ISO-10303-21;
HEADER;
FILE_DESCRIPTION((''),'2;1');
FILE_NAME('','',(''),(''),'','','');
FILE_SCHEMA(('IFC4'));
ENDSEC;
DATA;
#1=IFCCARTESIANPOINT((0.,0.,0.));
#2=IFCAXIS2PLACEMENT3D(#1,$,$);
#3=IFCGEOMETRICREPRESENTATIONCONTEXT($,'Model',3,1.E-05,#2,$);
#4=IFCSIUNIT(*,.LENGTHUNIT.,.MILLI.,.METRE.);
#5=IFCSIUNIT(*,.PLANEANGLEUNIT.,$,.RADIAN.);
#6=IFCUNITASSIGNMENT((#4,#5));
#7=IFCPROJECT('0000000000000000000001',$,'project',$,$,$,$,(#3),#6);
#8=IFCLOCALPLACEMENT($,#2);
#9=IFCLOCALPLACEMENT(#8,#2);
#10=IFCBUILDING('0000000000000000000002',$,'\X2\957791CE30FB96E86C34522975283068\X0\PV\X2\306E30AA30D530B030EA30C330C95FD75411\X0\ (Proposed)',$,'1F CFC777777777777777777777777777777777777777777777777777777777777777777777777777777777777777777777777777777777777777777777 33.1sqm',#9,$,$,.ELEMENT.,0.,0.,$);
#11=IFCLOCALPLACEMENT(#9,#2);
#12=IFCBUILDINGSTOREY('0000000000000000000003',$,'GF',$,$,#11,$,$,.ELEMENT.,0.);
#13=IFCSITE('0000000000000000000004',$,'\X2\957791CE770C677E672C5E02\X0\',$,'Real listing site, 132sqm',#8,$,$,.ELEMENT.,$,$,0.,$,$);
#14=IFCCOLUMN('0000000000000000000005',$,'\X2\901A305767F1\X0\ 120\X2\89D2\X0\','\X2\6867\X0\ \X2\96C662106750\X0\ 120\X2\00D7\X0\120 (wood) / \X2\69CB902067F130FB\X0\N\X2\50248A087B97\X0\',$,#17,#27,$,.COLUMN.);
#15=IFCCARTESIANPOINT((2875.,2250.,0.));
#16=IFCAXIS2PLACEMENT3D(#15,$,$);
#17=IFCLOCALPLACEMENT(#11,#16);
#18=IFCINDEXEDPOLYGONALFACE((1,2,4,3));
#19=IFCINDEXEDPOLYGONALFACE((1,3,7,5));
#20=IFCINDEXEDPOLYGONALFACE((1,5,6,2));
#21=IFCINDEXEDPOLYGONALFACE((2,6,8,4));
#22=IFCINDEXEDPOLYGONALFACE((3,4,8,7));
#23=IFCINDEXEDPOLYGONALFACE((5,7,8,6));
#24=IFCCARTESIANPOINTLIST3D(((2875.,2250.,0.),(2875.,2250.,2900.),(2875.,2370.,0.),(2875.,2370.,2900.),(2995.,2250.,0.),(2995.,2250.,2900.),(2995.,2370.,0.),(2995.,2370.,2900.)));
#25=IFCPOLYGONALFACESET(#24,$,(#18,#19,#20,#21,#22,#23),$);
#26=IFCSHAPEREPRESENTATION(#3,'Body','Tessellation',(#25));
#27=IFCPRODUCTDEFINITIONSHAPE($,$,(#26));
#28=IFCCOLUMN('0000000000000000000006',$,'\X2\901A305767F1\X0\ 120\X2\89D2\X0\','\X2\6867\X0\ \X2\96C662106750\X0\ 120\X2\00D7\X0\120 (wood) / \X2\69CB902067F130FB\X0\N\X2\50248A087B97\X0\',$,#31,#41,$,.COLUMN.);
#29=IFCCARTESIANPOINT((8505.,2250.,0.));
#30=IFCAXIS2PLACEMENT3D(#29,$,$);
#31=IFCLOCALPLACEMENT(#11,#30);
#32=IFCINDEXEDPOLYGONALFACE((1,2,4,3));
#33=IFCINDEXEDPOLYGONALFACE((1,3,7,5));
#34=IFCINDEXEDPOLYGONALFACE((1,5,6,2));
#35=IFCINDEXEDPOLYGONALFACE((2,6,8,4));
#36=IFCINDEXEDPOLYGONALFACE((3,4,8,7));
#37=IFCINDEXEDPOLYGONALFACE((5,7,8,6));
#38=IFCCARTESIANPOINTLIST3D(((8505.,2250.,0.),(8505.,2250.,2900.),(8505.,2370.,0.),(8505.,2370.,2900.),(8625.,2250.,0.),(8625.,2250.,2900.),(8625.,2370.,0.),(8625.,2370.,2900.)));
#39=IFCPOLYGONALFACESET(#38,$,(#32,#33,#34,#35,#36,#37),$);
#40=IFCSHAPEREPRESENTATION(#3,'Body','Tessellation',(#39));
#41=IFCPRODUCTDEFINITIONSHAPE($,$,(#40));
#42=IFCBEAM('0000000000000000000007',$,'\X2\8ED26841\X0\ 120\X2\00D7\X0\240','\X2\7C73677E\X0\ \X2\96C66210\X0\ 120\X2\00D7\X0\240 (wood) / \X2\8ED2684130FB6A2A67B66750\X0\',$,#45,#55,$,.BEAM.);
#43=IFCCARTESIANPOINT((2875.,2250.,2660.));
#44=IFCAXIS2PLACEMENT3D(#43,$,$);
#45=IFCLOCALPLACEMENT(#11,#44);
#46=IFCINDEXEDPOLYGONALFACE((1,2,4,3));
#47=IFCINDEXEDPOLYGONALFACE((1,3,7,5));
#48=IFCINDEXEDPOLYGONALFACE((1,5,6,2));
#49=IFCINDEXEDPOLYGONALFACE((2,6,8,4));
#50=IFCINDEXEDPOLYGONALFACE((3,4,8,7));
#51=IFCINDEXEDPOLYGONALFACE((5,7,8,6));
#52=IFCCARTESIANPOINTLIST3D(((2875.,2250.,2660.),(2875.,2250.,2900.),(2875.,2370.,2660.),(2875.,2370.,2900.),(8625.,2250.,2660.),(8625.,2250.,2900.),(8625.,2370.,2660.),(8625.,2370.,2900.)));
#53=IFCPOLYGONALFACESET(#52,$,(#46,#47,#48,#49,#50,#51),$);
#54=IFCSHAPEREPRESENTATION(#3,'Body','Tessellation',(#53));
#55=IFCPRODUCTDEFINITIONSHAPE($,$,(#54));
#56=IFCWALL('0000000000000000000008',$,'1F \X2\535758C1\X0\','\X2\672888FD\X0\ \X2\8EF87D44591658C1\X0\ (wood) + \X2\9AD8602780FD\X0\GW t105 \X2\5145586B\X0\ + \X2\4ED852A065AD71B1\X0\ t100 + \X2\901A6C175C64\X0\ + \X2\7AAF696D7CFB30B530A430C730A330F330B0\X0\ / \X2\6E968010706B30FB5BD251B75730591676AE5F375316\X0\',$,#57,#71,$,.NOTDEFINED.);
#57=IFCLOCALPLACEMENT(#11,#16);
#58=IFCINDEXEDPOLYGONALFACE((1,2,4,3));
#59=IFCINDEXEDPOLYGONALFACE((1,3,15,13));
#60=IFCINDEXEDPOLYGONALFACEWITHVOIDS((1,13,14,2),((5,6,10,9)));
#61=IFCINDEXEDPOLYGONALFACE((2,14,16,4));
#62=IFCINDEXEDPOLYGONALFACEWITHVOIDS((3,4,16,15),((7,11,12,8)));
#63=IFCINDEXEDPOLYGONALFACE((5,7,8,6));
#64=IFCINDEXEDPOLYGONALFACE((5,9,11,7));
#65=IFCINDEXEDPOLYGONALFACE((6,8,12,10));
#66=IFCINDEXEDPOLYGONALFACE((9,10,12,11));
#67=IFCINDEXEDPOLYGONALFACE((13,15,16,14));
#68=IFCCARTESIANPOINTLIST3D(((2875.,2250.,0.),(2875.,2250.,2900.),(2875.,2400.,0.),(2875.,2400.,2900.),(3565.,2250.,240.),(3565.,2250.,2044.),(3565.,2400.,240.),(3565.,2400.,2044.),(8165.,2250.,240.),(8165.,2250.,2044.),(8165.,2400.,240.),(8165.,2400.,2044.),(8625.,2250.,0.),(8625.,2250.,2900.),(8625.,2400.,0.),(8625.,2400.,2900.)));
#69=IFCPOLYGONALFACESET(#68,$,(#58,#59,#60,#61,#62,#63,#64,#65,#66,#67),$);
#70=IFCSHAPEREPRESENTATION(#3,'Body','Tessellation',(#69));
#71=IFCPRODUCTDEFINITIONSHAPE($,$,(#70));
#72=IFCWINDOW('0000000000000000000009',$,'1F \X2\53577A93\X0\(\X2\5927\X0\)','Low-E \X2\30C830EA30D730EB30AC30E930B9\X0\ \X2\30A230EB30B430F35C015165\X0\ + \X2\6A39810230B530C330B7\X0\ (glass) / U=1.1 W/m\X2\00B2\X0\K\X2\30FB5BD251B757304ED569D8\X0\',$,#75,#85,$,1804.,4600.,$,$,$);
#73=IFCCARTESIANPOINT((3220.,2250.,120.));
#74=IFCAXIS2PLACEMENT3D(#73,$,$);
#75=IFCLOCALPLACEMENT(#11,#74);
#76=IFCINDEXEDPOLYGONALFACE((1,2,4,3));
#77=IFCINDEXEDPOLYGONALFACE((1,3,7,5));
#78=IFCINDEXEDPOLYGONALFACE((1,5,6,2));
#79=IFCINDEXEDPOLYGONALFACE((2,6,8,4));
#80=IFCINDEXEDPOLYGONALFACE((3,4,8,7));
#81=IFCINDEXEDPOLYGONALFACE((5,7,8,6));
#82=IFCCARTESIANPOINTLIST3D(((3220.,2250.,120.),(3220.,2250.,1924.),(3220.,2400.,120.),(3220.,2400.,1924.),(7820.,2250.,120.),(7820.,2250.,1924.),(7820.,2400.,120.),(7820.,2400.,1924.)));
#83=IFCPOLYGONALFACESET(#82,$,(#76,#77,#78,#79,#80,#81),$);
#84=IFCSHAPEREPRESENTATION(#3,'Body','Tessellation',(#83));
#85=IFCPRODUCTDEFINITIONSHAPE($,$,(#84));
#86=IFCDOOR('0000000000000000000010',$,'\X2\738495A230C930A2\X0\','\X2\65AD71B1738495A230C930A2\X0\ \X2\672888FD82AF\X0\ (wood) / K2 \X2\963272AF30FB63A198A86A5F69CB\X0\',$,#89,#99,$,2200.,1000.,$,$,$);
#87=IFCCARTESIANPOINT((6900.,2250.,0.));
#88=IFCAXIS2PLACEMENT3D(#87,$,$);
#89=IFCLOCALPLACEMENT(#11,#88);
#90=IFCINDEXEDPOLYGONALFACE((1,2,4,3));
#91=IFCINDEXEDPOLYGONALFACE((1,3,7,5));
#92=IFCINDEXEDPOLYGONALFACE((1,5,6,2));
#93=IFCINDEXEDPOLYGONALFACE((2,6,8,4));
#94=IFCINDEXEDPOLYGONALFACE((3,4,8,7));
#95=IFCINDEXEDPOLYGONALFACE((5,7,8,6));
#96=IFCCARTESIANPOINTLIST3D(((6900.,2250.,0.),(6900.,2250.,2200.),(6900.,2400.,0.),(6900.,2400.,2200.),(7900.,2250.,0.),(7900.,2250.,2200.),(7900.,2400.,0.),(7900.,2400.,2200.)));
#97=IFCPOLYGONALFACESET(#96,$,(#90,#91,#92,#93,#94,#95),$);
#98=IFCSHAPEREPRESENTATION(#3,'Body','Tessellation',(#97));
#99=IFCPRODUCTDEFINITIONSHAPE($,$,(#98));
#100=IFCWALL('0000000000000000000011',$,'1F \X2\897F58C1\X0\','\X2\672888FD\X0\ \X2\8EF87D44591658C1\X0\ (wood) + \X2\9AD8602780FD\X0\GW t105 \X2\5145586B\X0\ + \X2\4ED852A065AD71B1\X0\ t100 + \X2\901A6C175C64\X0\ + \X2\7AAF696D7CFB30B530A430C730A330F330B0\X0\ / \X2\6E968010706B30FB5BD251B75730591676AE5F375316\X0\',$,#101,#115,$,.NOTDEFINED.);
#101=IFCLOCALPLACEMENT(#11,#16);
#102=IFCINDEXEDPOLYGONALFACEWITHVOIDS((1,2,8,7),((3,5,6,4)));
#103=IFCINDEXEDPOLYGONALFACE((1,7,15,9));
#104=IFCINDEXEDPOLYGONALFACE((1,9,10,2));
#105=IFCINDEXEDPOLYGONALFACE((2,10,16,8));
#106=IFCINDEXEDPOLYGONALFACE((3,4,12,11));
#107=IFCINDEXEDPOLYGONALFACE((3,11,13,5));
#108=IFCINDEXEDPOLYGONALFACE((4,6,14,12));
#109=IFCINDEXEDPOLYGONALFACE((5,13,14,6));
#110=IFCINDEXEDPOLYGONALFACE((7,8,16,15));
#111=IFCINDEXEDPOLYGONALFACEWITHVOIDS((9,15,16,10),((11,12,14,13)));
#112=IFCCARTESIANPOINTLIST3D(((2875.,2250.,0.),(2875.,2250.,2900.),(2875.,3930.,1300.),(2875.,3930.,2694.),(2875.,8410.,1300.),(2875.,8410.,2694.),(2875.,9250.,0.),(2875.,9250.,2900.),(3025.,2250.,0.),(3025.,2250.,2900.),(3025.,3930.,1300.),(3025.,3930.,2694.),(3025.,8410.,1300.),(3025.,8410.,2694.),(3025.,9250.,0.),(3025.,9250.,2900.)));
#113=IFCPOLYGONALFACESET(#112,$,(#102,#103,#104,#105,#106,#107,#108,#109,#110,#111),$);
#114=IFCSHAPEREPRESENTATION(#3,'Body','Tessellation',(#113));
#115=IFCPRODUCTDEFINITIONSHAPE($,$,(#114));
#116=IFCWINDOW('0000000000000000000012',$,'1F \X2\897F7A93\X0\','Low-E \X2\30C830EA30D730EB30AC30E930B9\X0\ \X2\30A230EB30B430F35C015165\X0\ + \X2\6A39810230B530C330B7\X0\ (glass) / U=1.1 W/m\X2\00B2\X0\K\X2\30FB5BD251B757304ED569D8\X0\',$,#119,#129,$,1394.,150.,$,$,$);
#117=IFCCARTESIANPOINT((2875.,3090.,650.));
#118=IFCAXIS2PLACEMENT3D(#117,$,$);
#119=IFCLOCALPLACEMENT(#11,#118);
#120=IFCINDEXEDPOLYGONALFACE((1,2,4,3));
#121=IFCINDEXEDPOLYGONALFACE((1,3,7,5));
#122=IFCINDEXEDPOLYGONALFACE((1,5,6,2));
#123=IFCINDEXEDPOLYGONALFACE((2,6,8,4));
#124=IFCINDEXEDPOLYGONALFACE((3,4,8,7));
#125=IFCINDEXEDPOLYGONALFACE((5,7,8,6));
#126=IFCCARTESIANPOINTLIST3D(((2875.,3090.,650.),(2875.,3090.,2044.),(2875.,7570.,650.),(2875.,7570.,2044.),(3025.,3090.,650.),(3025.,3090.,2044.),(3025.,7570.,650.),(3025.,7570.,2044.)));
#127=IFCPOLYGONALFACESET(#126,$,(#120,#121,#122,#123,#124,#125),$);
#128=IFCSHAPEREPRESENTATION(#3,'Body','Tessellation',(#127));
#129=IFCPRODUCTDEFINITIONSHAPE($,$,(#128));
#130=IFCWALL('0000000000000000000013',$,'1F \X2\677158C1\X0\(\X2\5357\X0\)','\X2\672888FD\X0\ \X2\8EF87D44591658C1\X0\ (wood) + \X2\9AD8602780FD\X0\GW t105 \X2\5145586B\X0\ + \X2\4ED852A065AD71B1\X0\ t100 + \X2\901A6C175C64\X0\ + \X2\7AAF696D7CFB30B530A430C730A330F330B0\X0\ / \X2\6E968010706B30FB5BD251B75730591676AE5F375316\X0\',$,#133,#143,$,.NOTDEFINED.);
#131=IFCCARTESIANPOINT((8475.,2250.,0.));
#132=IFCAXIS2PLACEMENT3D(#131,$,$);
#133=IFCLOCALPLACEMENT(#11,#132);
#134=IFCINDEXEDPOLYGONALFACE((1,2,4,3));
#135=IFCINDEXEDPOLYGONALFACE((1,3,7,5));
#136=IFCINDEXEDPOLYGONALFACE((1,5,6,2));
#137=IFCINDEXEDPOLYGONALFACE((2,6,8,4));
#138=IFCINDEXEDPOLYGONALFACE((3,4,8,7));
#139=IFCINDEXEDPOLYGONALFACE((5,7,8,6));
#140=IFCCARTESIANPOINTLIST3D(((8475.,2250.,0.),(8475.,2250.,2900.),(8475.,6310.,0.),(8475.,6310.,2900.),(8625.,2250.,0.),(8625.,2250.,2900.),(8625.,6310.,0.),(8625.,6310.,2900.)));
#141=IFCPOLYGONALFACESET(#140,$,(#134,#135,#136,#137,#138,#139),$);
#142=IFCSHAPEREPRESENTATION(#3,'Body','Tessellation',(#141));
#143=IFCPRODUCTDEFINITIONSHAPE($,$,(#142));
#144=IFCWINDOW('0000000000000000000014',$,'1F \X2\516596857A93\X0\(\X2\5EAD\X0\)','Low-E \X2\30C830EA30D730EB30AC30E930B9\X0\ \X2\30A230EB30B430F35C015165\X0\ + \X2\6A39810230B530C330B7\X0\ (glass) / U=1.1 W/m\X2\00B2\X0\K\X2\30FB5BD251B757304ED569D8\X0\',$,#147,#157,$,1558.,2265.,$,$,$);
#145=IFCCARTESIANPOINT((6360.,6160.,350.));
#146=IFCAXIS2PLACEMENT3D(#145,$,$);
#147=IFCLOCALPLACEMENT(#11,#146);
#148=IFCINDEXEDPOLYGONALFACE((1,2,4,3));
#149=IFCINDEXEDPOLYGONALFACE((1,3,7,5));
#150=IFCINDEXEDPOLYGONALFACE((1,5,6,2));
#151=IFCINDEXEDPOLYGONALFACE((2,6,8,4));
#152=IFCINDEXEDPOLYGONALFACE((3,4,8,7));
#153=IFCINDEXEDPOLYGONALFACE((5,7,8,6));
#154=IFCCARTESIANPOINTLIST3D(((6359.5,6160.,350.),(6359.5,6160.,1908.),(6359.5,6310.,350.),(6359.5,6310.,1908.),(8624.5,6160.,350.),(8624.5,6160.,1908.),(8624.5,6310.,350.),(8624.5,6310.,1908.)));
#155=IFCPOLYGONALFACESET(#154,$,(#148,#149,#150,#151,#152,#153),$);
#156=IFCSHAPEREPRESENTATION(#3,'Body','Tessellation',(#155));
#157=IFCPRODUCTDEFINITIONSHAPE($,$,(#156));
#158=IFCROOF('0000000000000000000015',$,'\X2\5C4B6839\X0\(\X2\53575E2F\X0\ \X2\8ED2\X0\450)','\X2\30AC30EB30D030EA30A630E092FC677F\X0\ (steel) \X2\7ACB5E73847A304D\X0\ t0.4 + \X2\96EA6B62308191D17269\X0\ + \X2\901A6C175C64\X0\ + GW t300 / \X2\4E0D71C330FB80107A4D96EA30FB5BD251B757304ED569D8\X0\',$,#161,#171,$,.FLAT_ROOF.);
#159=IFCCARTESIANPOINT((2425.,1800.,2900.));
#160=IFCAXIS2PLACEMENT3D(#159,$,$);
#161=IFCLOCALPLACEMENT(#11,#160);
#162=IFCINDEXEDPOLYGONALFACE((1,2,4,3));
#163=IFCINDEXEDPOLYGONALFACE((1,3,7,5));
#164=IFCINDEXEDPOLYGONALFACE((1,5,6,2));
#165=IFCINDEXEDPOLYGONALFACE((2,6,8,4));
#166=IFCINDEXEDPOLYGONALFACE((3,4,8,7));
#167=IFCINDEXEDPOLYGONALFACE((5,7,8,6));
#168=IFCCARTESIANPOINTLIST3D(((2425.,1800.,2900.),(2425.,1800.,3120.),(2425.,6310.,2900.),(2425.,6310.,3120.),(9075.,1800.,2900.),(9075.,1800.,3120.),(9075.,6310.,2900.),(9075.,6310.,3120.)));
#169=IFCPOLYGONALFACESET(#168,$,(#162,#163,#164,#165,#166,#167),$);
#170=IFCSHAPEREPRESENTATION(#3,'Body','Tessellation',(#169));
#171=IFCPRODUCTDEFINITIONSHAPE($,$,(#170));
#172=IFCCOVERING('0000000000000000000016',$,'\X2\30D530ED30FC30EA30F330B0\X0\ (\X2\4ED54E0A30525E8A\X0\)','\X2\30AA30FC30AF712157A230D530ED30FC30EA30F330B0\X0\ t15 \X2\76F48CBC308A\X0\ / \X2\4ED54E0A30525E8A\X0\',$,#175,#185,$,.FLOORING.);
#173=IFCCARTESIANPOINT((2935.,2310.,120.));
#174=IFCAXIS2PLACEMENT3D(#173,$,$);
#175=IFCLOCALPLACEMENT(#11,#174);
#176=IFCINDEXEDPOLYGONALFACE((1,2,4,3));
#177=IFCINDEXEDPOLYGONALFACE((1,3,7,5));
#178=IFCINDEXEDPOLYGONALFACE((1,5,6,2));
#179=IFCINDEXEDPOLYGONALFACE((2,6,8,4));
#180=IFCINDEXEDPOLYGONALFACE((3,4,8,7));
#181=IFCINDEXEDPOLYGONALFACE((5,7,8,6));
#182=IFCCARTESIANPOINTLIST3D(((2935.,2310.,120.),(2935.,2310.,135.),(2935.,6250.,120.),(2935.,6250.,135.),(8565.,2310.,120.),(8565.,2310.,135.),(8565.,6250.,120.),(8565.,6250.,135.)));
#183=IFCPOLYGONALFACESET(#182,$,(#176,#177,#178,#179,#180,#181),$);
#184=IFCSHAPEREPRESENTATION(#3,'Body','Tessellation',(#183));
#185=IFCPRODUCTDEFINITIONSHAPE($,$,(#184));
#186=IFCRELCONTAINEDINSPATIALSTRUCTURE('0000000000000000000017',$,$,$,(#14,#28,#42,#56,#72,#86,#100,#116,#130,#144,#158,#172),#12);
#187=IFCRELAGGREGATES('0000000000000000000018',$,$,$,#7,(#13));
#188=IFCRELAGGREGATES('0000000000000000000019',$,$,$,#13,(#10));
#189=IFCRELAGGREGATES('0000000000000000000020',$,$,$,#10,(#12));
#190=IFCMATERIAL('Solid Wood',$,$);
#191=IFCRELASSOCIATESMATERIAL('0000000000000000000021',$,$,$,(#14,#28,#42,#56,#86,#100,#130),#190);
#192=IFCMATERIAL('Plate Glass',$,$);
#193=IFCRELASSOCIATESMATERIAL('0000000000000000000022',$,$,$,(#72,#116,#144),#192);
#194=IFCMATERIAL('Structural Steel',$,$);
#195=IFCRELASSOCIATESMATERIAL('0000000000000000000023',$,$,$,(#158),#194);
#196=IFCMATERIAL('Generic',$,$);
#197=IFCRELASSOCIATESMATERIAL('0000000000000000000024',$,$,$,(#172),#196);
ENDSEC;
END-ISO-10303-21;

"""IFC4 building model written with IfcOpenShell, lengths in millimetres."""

from ifc_helpers import new_model, si_unit, frame, frame_2d, origin, place, context, project, spatial, rectangle, extrude, material, element, fill, save


model = new_model("IFC4")

# Units and contexts
model_context = context("Model", 3, precision=1e-05, world=origin())
ifc_project = project(units=[si_unit("LENGTHUNIT", "METRE", prefix="MILLI"), si_unit("PLANEANGLEUNIT", "RADIAN")], contexts=[model_context])

# Site, building, storey
site_placement = place(None, origin())
site = spatial("IfcSite", under=ifc_project, at=site_placement, Name="長野県松本市", ObjectType="Real listing site, 132sqm", CompositionType="ELEMENT", RefElevation=0.0)
building_placement = place(site_placement, origin())
building = spatial("IfcBuilding", under=site, at=building_placement, Name="長野・雨水利用とPVのオフグリッド志向 (Proposed)", ObjectType="1F CFC777777777777777777777777777777777777777777777777777777777777777777777777777777777777777777777777777777777777777777777 33.1sqm", CompositionType="ELEMENT", ElevationOfRefHeight=0.0, ElevationOfTerrain=0.0)
storey_placement = place(building_placement, origin())
storey = spatial("IfcBuildingStorey", under=building, at=storey_placement, Name="GF", CompositionType="ELEMENT", Elevation=0.0)

# Columns
ifc_material_1 = material(Name="Solid Wood")
column_1_placement = place(storey_placement, frame((2875.0, 2250.0, 0.0)))
element("IfcColumn", 1, at=column_1_placement, inside=storey, material=ifc_material_1, Name="通し柱 120角", Description="桧 集成材 120×120 (wood) / 構造柱・N値計算", PredefinedType="COLUMN", context=model_context, shape_type="SweptSolid", body=[
    extrude(rectangle(XDim=120.0, YDim=120.0, at=frame_2d((60.0, 60.0))), frame((2875.0, 2250.0, 0.0)), (0.0, 0.0, 1.0), 2900.0),
])
column_2_placement = place(storey_placement, frame((8505.0, 2250.0, 0.0)))
element("IfcColumn", 2, at=column_2_placement, inside=storey, material=ifc_material_1, Name="通し柱 120角", Description="桧 集成材 120×120 (wood) / 構造柱・N値計算", PredefinedType="COLUMN", context=model_context, shape_type="SweptSolid", body=[
    extrude(rectangle(XDim=120.0, YDim=120.0, at=frame_2d((60.0, 60.0))), frame((8505.0, 2250.0, 0.0)), (0.0, 0.0, 1.0), 2900.0),
])

# Beam
beam_1_placement = place(storey_placement, frame((2875.0, 2250.0, 2660.0)))
element("IfcBeam", 3, at=beam_1_placement, inside=storey, material=ifc_material_1, Name="軒桁 120×240", Description="米松 集成 120×240 (wood) / 軒桁・横架材", PredefinedType="BEAM", context=model_context, shape_type="SweptSolid", body=[
    extrude(rectangle(XDim=5750.0, YDim=120.0, at=frame_2d((2875.0, 60.0))), frame((2875.0, 2250.0, 2660.0)), (0.0, 0.0, 1.0), 240.0),
])

# Wall, openings, window, door
wall_1_placement = place(storey_placement, frame((2875.0, 2250.0, 0.0)))
wall_1 = element("IfcWall", 4, at=wall_1_placement, inside=storey, material=ifc_material_1, Name="1F 南壁", Description="木製 軸組外壁 (wood) + 高性能GW t105 充填 + 付加断熱 t100 + 通気層 + 窯業系サイディング / 準耐火・寒冷地外皮強化", PredefinedType="NOTDEFINED", context=model_context, shape_type="SweptSolid", body=[
    extrude(rectangle(XDim=5750.0, YDim=150.0, at=frame_2d((2875.0, 75.0))), frame((2875.0, 2250.0, 0.0)), (0.0, 0.0, 1.0), 2900.0),
])
opening_1_placement = place(storey_placement, frame((3220.0, 2250.0, 120.0)))
opening_1 = element("IfcOpeningElement", 5, at=opening_1_placement, cuts=wall_1, PredefinedType="NOTDEFINED", context=model_context, shape_type="SweptSolid", body=[
    extrude(rectangle(XDim=4600.0, YDim=150.0, at=frame_2d((2300.0, 75.0))), frame((3220.0, 2250.0, 120.0)), (0.0, 0.0, 1.0), 1804.0),
])
opening_2_placement = place(storey_placement, frame((6900.0, 2250.0, 0.0)))
opening_2 = element("IfcOpeningElement", 6, at=opening_2_placement, cuts=wall_1, PredefinedType="NOTDEFINED", context=model_context, shape_type="SweptSolid", body=[
    extrude(rectangle(XDim=1000.0, YDim=150.0, at=frame_2d((500.0, 75.0))), frame((6900.0, 2250.0, 0.0)), (0.0, 0.0, 1.0), 2200.0),
])
ifc_material_2 = material(Name="Plate Glass")
window_1_placement = place(storey_placement, frame((3220.0, 2250.0, 120.0)))
window_1 = element("IfcWindow", 7, at=window_1_placement, inside=storey, material=ifc_material_2, Name="1F 南窓(大)", Description="Low-E トリプルガラス アルゴン封入 + 樹脂サッシ (glass) / U=1.1 W/m²K・寒冷地仕様", OverallHeight=1804.0, OverallWidth=4600.0, context=model_context, shape_type="SweptSolid", body=[
    extrude(rectangle(XDim=4600.0, YDim=150.0, at=frame_2d((2300.0, 75.0))), frame((3220.0, 2250.0, 120.0)), (0.0, 0.0, 1.0), 1804.0),
])
fill(opening_1, window_1)
door_1_placement = place(storey_placement, frame((6900.0, 2250.0, 0.0)))
door_1 = element("IfcDoor", 8, at=door_1_placement, inside=storey, material=ifc_material_1, Name="玄関ドア", Description="断熱玄関ドア 木製芯 (wood) / K2 防犯・採風機構", OverallHeight=2200.0, OverallWidth=1000.0, context=model_context, shape_type="SweptSolid", body=[
    extrude(rectangle(XDim=1000.0, YDim=150.0, at=frame_2d((500.0, 75.0))), frame((6900.0, 2250.0, 0.0)), (0.0, 0.0, 1.0), 2200.0),
])
fill(opening_2, door_1)

# Walls, openings, windows
wall_2_placement = place(storey_placement, frame((2875.0, 2250.0, 0.0)))
wall_2 = element("IfcWall", 9, at=wall_2_placement, inside=storey, material=ifc_material_1, Name="1F 西壁", Description="木製 軸組外壁 (wood) + 高性能GW t105 充填 + 付加断熱 t100 + 通気層 + 窯業系サイディング / 準耐火・寒冷地外皮強化", PredefinedType="NOTDEFINED", context=model_context, shape_type="SweptSolid", body=[
    extrude(rectangle(XDim=150.0, YDim=7000.0, at=frame_2d((75.0, 3500.0))), frame((2875.0, 2250.0, 0.0)), (0.0, 0.0, 1.0), 2900.0),
])
opening_3_placement = place(storey_placement, frame((2875.0, 3090.0, 650.0)))
opening_3 = element("IfcOpeningElement", 10, at=opening_3_placement, cuts=wall_2, PredefinedType="NOTDEFINED", context=model_context, shape_type="SweptSolid", body=[
    extrude(rectangle(XDim=150.0, YDim=4480.0, at=frame_2d((75.0, 2240.0))), frame((2875.0, 3090.0, 650.0)), (0.0, 0.0, 1.0), 1394.0),
])
window_2_placement = place(storey_placement, frame((2875.0, 3090.0, 650.0)))
window_2 = element("IfcWindow", 11, at=window_2_placement, inside=storey, material=ifc_material_2, Name="1F 西窓", Description="Low-E トリプルガラス アルゴン封入 + 樹脂サッシ (glass) / U=1.1 W/m²K・寒冷地仕様", OverallHeight=1394.0, OverallWidth=150.0, context=model_context, shape_type="SweptSolid", body=[
    extrude(rectangle(XDim=150.0, YDim=4480.0, at=frame_2d((75.0, 2240.0))), frame((2875.0, 3090.0, 650.0)), (0.0, 0.0, 1.0), 1394.0),
])
fill(opening_3, window_2)
wall_3_placement = place(storey_placement, frame((8475.0, 2250.0, 0.0)))
wall_3 = element("IfcWall", 12, at=wall_3_placement, inside=storey, material=ifc_material_1, Name="1F 東壁(南)", Description="木製 軸組外壁 (wood) + 高性能GW t105 充填 + 付加断熱 t100 + 通気層 + 窯業系サイディング / 準耐火・寒冷地外皮強化", PredefinedType="NOTDEFINED", context=model_context, shape_type="SweptSolid", body=[
    extrude(rectangle(XDim=150.0, YDim=4060.0, at=frame_2d((75.0, 2030.0))), frame((8475.0, 2250.0, 0.0)), (0.0, 0.0, 1.0), 2900.0),
])
opening_4_placement = place(storey_placement, frame((6360.0, 6160.0, 350.0)))
opening_4 = element("IfcOpeningElement", 13, at=opening_4_placement, cuts=wall_3, PredefinedType="NOTDEFINED", context=model_context, shape_type="SweptSolid", body=[
    extrude(rectangle(XDim=2265.0, YDim=150.0, at=frame_2d((1132.0, 75.0))), frame((6360.0, 6160.0, 350.0)), (0.0, 0.0, 1.0), 1558.0),
])
window_3_placement = place(storey_placement, frame((6360.0, 6160.0, 350.0)))
window_3 = element("IfcWindow", 14, at=window_3_placement, inside=storey, material=ifc_material_2, Name="1F 入隅窓(庭)", Description="Low-E トリプルガラス アルゴン封入 + 樹脂サッシ (glass) / U=1.1 W/m²K・寒冷地仕様", OverallHeight=1558.0, OverallWidth=2265.0, context=model_context, shape_type="SweptSolid", body=[
    extrude(rectangle(XDim=2265.0, YDim=150.0, at=frame_2d((1132.0, 75.0))), frame((6360.0, 6160.0, 350.0)), (0.0, 0.0, 1.0), 1558.0),
])
fill(opening_4, window_3)

# Roof
ifc_material_3 = material(Name="Structural Steel")
roof_placement = place(storey_placement, frame((2425.0, 1800.0, 2900.0)))
element("IfcRoof", 15, at=roof_placement, inside=storey, material=ifc_material_3, Name="屋根(南帯 軒450)", Description="ガルバリウム鋼板 (steel) 立平葺き t0.4 + 雪止め金物 + 通気層 + GW t300 / 不燃・耐積雪・寒冷地仕様", PredefinedType="FLAT_ROOF", context=model_context, shape_type="SweptSolid", body=[
    extrude(rectangle(XDim=6650.0, YDim=4510.0, at=frame_2d((3325.0, 2255.0))), frame((2425.0, 1800.0, 2900.0)), (0.0, 0.0, 1.0), 220.0),
])

# Covering
ifc_material_4 = material(Name="Generic")
covering_1_placement = place(storey_placement, frame((2935.0, 2310.0, 120.0)))
element("IfcCovering", 16, at=covering_1_placement, inside=storey, material=ifc_material_4, Name="フローリング (仕上げ床)", Description="オーク無垢フローリング t15 直貼り / 仕上げ床", PredefinedType="FLOORING", context=model_context, shape_type="SweptSolid", body=[
    extrude(rectangle(XDim=5630.0, YDim=3940.0, at=frame_2d((2815.0, 1970.0))), frame((2935.0, 2310.0, 120.0)), (0.0, 0.0, 1.0), 15.0),
])

save(model, "model.ifc")
